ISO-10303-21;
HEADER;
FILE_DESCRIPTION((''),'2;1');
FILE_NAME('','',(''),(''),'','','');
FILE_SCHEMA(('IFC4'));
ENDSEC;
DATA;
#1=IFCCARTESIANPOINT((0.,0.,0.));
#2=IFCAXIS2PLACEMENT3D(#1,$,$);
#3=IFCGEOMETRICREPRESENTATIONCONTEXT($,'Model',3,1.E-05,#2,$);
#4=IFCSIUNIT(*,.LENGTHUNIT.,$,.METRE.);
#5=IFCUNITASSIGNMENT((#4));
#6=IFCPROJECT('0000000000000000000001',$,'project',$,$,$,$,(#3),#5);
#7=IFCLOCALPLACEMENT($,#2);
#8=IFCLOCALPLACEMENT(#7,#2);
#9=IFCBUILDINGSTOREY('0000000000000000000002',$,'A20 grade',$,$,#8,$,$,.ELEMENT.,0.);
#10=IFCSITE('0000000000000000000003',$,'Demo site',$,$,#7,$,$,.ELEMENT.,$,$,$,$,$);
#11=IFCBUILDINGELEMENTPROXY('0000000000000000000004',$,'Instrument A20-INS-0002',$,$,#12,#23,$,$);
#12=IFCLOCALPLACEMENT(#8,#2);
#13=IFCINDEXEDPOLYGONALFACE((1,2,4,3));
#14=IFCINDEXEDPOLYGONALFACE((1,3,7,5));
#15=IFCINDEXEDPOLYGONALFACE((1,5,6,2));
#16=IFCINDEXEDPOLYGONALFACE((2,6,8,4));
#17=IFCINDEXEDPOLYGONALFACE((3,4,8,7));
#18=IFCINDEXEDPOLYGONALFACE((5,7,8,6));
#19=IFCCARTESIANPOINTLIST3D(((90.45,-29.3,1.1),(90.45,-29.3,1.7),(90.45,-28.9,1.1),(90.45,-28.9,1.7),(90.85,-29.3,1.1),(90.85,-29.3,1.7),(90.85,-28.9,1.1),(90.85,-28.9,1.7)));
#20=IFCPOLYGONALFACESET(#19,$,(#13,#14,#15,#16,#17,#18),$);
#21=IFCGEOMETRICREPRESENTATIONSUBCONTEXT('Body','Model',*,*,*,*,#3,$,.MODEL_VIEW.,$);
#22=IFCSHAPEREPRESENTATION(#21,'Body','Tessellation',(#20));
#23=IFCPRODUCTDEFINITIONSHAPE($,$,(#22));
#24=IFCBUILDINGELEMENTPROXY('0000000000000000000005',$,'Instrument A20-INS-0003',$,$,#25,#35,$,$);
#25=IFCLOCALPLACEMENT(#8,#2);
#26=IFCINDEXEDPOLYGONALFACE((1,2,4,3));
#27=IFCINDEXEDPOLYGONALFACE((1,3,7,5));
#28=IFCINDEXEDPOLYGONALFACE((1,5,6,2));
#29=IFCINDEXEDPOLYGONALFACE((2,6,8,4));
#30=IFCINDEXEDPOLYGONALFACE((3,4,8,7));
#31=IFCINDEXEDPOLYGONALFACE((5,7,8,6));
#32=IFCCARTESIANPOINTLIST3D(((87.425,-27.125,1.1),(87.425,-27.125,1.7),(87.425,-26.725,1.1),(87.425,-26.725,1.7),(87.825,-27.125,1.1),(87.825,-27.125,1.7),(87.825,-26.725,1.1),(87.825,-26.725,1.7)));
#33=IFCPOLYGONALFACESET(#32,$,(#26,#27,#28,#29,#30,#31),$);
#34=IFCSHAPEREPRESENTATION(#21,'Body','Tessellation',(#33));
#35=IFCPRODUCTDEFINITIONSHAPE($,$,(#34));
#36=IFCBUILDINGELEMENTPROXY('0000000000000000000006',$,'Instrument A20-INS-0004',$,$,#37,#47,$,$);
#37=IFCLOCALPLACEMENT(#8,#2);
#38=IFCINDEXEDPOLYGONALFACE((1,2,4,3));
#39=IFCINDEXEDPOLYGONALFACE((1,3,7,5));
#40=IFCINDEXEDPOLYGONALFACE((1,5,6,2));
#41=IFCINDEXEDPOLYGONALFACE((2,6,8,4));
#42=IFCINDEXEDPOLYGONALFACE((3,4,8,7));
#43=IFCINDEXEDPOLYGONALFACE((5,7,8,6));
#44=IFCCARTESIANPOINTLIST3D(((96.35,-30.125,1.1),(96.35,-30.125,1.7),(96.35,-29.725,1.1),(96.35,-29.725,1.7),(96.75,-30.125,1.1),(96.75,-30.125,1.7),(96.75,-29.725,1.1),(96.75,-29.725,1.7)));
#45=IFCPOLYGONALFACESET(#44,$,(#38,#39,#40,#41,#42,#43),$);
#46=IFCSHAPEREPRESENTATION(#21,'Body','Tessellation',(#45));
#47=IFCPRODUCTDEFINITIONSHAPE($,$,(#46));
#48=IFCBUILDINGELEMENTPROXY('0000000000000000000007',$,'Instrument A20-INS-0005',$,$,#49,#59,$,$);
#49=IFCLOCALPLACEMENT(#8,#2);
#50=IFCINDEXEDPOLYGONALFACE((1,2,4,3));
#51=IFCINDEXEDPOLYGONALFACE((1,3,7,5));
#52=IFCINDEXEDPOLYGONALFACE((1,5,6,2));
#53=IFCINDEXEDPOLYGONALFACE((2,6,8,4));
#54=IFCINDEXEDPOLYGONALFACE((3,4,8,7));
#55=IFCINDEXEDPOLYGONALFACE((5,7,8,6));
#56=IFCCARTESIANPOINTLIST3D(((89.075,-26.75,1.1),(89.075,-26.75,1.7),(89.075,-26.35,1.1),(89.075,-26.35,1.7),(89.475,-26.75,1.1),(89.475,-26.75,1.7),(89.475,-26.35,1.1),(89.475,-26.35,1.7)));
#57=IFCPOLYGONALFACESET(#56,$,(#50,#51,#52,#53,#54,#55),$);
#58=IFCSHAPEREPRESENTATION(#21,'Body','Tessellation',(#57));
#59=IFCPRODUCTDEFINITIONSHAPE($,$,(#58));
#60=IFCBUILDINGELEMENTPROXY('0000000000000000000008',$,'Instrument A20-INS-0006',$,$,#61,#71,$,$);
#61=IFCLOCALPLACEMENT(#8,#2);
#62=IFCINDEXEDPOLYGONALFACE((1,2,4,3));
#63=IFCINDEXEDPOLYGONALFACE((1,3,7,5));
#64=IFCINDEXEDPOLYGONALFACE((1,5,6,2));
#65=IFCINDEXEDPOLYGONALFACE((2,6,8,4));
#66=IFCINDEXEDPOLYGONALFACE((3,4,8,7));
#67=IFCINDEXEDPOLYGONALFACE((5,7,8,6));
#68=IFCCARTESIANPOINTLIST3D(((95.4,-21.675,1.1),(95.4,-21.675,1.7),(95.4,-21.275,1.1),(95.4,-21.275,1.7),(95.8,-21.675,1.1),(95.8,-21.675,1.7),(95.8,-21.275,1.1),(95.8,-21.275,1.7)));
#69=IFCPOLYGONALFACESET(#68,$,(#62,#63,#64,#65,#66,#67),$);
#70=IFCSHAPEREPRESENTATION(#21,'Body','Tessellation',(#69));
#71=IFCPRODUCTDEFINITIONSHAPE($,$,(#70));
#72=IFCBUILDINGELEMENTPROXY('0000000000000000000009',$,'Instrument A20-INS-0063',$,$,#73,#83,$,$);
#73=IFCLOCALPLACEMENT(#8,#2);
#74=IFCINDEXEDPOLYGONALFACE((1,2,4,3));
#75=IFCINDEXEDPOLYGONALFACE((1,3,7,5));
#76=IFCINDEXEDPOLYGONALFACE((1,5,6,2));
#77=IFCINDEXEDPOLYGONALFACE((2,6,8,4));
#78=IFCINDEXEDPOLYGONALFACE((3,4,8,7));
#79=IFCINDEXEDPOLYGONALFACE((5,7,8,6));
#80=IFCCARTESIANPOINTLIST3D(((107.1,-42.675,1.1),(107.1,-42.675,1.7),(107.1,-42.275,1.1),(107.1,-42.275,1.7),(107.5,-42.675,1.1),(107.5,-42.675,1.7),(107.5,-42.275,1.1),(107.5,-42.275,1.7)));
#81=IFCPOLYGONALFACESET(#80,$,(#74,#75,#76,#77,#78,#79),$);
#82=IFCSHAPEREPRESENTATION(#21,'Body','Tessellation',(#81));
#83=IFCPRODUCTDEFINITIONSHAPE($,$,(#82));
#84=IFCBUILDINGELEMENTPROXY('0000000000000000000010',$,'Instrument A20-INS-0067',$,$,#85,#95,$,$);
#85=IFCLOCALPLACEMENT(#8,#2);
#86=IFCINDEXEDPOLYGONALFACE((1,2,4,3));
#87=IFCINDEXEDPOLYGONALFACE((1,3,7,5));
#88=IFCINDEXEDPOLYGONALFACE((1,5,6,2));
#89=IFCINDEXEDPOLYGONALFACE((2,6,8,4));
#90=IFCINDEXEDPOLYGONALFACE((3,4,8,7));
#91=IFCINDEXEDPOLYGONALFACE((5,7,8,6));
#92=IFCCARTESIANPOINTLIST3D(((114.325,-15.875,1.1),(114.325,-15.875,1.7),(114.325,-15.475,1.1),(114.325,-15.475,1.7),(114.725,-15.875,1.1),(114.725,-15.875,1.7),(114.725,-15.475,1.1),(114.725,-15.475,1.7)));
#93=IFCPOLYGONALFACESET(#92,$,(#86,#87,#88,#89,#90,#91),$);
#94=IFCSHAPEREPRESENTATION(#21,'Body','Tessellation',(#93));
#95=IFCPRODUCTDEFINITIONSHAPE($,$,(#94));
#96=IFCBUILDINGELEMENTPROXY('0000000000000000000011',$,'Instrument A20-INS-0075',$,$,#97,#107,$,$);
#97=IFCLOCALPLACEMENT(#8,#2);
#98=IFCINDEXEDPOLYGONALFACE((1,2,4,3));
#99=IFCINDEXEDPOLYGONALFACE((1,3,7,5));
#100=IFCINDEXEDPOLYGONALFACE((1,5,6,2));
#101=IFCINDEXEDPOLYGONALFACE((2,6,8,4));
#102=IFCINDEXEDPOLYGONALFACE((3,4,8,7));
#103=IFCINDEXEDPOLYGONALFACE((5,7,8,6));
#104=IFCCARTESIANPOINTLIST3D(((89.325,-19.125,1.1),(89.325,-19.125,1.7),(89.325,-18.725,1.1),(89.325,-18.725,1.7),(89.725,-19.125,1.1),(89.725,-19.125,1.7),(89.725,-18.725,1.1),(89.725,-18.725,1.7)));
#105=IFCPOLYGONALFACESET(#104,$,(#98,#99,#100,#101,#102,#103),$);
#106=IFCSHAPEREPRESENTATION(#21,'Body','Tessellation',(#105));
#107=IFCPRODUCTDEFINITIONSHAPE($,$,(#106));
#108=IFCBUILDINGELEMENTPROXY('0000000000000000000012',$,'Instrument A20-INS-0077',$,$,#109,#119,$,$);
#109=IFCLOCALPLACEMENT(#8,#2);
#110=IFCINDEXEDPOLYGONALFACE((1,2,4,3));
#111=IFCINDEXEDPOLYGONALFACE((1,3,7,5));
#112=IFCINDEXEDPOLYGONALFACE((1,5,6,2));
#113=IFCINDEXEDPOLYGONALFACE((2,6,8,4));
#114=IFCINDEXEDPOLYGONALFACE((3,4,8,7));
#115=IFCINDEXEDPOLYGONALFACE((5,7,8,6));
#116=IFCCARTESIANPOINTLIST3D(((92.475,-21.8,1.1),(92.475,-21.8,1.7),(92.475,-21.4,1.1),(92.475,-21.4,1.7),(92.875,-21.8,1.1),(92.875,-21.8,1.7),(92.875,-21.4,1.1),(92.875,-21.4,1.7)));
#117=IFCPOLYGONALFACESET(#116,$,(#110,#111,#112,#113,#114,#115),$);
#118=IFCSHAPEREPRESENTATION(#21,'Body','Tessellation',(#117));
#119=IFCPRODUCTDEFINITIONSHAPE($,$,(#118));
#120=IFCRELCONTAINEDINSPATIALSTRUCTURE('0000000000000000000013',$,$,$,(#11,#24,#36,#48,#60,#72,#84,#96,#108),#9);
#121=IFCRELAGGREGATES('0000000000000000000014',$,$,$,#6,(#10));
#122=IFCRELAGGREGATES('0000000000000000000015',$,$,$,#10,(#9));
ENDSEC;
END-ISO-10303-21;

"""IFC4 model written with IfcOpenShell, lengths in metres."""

from ifc_helpers import new_model, si_unit, frame, origin, place, context, subcontext, project, spatial, rectangle, extrude, element, save


model = new_model("IFC4")

# Units and contexts
model_context = context("Model", 3, precision=1e-05, world=origin())
body_context = subcontext(model_context, "Body", "Model", "MODEL_VIEW")
ifc_project = project(units=[si_unit("LENGTHUNIT", "METRE")], contexts=[model_context])

# Site, storey
site_placement = place(None, origin())
site = spatial("IfcSite", under=ifc_project, at=site_placement, Name="Demo site", CompositionType="ELEMENT")
storey_placement = place(site_placement, origin())
storey = spatial("IfcBuildingStorey", under=site, at=storey_placement, Name="A20 grade", CompositionType="ELEMENT", Elevation=0.0)

# Building element proxies
for number, where, name in (
    (1, (90.65, -29.1, 1.1), "Instrument A20-INS-0002"),
    (2, (87.625, -26.925, 1.1), "Instrument A20-INS-0003"),
    (3, (96.55, -29.925, 1.1), "Instrument A20-INS-0004"),
    (4, (89.275, -26.55, 1.1), "Instrument A20-INS-0005"),
    (5, (95.6, -21.475, 1.1), "Instrument A20-INS-0006"),
    (6, (107.3, -42.475, 1.1), "Instrument A20-INS-0063"),
    (7, (114.525, -15.675, 1.1), "Instrument A20-INS-0067"),
    (8, (89.525, -18.925, 1.1), "Instrument A20-INS-0075"),
    (9, (92.675, -21.6, 1.1), "Instrument A20-INS-0077"),
):
    element("IfcBuildingElementProxy", number, at=place(storey_placement, frame(where)), inside=storey, Name=name, context=body_context, shape_type="SweptSolid", body=[
        extrude(rectangle(XDim=0.4, YDim=0.4), origin(), (0.0, 0.0, 1.0), 0.6),
    ])

save(model, "model.ifc")
